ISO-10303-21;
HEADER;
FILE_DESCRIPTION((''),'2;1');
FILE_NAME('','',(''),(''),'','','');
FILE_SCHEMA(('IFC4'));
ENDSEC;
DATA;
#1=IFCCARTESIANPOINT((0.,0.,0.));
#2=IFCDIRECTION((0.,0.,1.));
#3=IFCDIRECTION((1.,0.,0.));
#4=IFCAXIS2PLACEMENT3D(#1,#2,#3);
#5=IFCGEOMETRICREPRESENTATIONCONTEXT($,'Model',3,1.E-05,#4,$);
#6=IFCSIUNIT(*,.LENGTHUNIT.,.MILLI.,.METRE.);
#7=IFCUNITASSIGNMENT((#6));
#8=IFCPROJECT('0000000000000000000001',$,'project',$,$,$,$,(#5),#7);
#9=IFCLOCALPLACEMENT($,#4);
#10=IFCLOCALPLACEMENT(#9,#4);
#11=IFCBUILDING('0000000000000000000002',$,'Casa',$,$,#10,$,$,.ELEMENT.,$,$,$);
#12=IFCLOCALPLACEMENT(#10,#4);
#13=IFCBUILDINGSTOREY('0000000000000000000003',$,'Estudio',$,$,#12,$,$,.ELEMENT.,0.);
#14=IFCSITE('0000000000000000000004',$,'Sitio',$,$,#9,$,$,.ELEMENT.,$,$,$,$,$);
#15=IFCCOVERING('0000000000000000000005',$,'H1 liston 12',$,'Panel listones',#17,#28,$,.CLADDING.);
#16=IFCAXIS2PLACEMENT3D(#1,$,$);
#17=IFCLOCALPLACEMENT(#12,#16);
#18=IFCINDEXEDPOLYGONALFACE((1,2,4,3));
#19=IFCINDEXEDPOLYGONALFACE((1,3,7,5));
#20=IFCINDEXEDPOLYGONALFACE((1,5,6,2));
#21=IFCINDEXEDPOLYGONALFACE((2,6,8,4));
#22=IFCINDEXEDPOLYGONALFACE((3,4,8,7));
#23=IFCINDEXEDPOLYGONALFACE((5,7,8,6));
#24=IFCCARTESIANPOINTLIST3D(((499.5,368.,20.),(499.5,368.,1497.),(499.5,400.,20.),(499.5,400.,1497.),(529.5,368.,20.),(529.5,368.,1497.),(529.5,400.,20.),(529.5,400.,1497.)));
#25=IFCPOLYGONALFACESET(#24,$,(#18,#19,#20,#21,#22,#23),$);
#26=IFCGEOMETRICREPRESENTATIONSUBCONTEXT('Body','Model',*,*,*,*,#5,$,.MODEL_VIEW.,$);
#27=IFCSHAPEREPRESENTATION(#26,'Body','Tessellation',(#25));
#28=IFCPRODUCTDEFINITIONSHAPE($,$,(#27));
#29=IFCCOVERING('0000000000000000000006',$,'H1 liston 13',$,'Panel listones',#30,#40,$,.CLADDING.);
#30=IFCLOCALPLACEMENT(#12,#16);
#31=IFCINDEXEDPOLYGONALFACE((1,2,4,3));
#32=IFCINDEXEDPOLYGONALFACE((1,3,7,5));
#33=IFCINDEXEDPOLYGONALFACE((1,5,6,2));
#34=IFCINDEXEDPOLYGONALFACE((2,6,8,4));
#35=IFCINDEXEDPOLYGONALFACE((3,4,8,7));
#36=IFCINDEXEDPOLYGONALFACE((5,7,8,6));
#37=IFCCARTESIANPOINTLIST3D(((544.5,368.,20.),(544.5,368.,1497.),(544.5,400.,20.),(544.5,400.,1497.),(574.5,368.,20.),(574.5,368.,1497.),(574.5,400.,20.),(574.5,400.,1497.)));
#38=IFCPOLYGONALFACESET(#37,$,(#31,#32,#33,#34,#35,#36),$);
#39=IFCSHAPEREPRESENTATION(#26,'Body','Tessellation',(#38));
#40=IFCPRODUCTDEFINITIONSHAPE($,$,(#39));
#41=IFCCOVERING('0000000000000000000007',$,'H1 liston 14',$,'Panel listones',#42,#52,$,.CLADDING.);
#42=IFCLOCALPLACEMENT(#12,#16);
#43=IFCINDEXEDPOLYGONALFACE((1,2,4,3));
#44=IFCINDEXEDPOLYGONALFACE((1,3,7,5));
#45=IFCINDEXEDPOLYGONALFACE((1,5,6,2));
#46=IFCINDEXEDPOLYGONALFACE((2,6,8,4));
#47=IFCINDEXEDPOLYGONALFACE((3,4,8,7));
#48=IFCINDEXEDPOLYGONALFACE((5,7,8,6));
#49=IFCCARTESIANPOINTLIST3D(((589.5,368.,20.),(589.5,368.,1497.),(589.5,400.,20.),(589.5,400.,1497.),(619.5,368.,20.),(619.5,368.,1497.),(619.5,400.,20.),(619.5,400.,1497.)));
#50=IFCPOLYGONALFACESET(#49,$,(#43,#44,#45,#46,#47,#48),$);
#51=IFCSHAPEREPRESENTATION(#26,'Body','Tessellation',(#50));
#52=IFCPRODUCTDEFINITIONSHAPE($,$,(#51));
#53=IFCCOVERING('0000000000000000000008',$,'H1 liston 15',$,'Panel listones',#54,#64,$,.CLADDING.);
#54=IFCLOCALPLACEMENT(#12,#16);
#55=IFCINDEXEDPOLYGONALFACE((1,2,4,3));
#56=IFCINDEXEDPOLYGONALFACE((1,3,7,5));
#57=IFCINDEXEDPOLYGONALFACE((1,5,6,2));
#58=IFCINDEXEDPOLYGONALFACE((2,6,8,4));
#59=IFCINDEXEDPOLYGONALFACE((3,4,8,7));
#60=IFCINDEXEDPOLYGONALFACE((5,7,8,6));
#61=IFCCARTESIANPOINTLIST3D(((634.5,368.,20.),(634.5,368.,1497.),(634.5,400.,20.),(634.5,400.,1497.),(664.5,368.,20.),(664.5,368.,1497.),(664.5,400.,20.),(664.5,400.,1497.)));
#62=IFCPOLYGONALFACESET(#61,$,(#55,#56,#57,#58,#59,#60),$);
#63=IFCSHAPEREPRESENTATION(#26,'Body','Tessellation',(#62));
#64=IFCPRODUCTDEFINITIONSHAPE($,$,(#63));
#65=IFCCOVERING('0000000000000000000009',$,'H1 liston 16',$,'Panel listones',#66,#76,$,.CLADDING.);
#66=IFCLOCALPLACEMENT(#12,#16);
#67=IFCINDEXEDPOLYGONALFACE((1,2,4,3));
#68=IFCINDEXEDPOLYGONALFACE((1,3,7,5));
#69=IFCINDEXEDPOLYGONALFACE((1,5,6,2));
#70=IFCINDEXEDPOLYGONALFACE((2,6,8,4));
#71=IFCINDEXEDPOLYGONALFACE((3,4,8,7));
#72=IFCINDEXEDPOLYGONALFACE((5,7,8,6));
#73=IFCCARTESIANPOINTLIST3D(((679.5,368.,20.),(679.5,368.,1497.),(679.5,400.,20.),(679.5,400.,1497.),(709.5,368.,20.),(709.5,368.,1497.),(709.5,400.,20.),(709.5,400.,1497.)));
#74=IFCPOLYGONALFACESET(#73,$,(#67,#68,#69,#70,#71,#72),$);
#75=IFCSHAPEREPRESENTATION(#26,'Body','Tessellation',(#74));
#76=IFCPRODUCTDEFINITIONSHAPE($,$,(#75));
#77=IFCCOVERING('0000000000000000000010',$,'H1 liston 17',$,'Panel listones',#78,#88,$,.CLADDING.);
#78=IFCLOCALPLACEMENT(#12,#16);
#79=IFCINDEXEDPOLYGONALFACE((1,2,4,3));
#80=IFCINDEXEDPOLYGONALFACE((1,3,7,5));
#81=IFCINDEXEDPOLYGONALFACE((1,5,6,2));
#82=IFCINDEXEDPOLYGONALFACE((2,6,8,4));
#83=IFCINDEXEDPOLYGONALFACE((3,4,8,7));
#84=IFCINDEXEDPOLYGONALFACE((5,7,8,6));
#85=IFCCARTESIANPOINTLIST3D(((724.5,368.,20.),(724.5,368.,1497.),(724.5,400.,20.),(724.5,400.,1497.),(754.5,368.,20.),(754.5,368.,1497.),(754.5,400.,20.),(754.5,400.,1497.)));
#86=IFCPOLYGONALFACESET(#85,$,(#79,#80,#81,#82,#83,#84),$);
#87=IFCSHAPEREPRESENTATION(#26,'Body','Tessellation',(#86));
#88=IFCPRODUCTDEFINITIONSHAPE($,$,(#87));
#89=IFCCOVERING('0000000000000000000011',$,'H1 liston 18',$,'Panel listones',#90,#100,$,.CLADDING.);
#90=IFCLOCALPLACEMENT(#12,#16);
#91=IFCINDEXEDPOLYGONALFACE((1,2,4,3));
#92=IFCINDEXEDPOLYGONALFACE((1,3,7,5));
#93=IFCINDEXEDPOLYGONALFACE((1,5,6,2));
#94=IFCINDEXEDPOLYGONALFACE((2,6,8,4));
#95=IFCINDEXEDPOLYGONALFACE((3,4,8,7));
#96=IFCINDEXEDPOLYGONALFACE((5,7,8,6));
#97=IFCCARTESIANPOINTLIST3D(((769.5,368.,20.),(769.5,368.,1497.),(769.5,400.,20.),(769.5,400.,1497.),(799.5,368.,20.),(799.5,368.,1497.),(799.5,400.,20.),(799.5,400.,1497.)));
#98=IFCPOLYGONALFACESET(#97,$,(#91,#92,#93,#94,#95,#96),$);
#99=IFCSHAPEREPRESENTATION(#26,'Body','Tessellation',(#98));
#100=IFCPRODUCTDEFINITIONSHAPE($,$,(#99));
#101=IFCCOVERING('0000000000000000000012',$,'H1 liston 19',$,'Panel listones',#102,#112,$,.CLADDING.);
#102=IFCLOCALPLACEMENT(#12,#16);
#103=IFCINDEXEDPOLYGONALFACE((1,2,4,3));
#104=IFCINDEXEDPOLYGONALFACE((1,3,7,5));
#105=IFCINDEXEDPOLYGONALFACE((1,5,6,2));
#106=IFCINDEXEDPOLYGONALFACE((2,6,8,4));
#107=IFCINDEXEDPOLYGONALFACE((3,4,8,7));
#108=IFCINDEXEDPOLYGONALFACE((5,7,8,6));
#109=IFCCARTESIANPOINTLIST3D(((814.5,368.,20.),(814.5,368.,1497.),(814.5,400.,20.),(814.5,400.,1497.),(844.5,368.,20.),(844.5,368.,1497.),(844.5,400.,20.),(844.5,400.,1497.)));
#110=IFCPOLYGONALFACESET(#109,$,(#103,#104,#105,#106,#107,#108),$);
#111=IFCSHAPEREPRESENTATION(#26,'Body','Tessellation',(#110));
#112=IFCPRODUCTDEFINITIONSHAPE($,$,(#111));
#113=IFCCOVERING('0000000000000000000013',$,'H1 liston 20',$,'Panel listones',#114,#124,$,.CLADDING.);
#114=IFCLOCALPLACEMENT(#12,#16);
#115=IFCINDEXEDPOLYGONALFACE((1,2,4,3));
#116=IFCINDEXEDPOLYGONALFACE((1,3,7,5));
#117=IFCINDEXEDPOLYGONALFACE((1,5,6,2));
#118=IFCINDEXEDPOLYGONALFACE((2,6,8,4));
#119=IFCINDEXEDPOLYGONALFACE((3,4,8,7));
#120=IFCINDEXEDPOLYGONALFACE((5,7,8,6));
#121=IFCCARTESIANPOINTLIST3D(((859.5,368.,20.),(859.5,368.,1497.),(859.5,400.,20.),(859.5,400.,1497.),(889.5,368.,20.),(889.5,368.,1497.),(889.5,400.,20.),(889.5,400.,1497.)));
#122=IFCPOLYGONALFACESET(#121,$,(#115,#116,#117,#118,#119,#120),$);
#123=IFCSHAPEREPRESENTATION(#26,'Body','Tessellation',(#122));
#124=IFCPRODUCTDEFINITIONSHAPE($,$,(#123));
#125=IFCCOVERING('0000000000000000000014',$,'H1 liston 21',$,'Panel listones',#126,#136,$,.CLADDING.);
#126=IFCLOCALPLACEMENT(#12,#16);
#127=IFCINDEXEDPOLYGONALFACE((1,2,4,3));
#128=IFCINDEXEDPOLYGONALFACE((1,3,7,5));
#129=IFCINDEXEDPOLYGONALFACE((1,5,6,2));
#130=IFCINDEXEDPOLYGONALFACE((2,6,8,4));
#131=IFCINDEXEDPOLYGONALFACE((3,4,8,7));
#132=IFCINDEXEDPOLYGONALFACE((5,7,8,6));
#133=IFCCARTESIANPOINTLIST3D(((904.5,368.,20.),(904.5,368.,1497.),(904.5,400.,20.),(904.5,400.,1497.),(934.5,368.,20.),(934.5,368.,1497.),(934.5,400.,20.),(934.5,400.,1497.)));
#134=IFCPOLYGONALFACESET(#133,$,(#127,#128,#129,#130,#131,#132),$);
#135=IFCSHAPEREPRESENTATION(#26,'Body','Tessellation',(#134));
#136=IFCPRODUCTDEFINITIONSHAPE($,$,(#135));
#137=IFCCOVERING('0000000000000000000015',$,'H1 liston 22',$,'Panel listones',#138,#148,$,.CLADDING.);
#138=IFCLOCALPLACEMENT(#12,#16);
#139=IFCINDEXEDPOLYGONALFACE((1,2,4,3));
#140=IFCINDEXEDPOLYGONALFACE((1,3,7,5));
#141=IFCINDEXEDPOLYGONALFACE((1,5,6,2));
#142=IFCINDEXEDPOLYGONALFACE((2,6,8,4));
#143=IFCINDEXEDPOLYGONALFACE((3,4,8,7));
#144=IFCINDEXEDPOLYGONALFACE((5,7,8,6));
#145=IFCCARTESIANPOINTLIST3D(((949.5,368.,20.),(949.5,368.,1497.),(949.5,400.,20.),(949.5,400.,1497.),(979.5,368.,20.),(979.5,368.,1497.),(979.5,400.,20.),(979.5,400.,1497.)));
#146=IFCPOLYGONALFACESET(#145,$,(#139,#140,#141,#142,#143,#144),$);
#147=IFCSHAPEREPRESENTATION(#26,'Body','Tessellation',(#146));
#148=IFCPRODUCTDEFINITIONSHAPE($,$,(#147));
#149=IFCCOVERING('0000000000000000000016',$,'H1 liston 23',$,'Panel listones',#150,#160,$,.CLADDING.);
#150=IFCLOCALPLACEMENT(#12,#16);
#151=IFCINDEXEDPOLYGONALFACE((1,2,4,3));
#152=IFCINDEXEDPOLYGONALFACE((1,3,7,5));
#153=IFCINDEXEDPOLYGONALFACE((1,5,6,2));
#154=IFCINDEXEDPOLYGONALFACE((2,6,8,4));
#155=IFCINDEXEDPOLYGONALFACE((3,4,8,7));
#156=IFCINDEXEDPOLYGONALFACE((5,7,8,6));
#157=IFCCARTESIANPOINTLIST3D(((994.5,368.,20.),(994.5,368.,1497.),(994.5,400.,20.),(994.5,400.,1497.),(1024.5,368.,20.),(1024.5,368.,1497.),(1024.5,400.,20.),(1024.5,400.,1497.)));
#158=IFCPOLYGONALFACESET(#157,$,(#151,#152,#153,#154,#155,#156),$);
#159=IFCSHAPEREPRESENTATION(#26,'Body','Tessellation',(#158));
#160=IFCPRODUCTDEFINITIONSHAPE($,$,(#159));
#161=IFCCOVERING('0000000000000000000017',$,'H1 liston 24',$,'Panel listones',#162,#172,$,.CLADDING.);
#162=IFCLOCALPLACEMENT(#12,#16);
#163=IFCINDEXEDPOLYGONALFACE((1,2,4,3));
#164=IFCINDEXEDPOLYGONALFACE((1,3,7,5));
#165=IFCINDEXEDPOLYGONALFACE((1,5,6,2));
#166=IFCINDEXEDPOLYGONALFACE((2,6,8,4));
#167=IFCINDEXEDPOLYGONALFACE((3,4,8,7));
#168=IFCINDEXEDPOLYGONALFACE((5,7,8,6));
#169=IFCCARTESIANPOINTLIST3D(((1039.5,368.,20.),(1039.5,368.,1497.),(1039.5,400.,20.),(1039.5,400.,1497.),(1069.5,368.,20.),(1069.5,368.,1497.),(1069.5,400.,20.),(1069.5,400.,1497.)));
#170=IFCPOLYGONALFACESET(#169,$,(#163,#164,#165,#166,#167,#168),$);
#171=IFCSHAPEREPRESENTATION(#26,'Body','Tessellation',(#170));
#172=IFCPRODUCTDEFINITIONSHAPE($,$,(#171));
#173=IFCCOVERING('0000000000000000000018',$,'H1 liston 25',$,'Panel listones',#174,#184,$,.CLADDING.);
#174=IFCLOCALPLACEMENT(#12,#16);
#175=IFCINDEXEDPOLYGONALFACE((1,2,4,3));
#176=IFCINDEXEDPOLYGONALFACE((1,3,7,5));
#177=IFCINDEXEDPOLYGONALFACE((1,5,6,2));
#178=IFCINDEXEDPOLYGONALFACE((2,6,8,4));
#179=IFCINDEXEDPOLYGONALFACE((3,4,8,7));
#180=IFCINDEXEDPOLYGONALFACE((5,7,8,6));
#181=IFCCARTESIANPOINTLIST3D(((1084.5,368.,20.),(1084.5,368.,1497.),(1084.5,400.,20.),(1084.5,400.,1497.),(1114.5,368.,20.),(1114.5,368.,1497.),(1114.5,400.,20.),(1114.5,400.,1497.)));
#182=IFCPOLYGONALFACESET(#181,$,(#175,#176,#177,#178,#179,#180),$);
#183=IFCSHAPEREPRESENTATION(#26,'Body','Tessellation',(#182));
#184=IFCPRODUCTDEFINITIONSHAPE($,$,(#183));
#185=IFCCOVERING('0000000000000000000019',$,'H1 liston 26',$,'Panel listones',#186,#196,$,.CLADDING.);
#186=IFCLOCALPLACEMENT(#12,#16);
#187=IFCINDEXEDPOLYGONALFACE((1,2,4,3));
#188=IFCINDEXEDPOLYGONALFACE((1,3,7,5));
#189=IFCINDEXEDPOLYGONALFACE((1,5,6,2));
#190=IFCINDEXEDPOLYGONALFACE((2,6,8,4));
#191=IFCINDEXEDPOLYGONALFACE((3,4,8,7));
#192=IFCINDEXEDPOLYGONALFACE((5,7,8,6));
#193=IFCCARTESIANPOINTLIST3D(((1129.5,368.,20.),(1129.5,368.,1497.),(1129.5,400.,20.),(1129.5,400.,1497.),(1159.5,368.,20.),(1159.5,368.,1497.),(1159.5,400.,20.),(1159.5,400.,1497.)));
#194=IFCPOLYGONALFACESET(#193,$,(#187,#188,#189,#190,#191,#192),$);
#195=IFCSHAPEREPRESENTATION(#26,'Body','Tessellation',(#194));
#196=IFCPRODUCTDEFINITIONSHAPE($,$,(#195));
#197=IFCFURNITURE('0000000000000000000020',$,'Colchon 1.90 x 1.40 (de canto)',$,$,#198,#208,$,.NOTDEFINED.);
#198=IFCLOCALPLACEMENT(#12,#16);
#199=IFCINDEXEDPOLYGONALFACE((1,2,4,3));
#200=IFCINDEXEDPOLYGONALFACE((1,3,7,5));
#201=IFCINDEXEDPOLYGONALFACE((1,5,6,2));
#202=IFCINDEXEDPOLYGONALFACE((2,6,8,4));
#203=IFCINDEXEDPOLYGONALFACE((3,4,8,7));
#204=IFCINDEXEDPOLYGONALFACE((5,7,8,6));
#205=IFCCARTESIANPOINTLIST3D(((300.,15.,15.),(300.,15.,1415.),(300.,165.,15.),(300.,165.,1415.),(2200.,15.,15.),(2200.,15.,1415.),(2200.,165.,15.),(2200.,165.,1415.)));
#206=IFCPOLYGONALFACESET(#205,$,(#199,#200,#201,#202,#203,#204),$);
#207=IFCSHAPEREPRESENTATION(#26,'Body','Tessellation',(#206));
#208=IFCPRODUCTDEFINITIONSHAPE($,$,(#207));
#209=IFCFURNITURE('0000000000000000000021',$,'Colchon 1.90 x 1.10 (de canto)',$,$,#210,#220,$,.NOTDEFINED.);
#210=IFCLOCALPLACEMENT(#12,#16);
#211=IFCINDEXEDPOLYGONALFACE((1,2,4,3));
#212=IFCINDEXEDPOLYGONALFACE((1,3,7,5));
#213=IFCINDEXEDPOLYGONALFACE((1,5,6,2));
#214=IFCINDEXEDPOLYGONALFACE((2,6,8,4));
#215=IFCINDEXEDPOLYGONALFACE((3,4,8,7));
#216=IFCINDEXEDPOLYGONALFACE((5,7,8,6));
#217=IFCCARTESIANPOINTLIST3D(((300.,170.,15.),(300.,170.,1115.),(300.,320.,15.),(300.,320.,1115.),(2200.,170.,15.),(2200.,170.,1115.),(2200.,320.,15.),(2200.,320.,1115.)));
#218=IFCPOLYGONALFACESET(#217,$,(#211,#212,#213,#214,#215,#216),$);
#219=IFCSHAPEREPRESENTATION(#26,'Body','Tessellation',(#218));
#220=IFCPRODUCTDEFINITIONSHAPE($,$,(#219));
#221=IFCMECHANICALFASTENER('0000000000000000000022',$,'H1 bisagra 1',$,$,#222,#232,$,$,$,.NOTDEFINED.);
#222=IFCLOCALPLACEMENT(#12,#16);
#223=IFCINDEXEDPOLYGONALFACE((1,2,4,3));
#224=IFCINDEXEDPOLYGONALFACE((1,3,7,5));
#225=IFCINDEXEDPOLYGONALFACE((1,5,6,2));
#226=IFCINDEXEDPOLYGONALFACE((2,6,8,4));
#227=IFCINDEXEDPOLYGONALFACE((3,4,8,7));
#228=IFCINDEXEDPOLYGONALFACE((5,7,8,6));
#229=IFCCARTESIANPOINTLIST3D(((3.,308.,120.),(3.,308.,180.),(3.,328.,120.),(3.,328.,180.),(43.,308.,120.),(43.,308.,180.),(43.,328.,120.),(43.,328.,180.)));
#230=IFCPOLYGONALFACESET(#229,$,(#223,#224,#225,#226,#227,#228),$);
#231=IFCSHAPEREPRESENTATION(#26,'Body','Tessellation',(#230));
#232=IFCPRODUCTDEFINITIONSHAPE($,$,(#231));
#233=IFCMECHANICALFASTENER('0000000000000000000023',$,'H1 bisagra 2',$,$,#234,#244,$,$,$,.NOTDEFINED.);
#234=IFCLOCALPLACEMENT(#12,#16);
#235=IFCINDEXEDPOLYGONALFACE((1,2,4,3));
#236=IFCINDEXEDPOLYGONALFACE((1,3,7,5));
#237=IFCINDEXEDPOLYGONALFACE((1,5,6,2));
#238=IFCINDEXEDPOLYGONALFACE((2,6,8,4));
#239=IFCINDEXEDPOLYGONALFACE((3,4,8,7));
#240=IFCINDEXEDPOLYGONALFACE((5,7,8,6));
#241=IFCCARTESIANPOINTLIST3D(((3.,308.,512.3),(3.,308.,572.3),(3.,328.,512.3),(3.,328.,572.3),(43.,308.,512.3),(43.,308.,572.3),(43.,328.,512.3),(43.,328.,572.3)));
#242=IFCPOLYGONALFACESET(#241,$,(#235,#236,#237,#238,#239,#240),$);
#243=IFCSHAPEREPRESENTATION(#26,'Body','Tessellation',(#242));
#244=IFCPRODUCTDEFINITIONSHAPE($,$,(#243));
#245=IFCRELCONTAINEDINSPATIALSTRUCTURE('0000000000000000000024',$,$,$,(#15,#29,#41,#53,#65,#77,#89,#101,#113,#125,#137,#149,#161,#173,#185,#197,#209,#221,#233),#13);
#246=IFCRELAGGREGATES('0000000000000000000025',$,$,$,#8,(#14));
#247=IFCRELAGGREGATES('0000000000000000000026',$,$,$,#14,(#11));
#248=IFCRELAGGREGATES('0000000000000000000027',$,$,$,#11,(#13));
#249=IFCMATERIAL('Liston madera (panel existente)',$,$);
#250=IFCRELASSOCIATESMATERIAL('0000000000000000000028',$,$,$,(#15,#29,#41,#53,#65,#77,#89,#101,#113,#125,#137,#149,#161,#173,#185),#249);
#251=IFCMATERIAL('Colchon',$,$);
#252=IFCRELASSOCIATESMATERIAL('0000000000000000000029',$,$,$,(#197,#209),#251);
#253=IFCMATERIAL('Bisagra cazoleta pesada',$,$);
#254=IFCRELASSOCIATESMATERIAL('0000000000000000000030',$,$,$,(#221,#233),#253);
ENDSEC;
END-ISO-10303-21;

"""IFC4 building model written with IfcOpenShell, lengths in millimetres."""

from ifc_helpers import new_model, si_unit, frame, frame_2d, origin_with_axes, place, context, subcontext, project, spatial, rectangle, extrude, material, element, save


model = new_model("IFC4")

# Units and contexts
model_context = context("Model", 3, precision=1e-05, world=origin_with_axes())
body_context = subcontext(model_context, "Body", "Model", "MODEL_VIEW")
ifc_project = project(units=[si_unit("LENGTHUNIT", "METRE", prefix="MILLI")], contexts=[model_context])

# Site, building, storey
site_placement = place(None, origin_with_axes())
site = spatial("IfcSite", under=ifc_project, at=site_placement, Name="Sitio", CompositionType="ELEMENT")
building_placement = place(site_placement, origin_with_axes())
building = spatial("IfcBuilding", under=site, at=building_placement, Name="Casa", CompositionType="ELEMENT")
storey_placement = place(building_placement, origin_with_axes())
storey = spatial("IfcBuildingStorey", under=building, at=storey_placement, Name="Estudio", CompositionType="ELEMENT", Elevation=0.0)

# Coverings
ifc_material_1 = material(Name="Liston madera (panel existente)")
for number, where, z_axis, x_axis, name in (
    (1, (499.5, 368.0, 20.0), (0.0, 0.0, 1.0), (1.0, 0.0, 0.0), "H1 liston 12"),
    (2, (544.5, 368.0, 20.0), (0.0, 0.0, 1.0), (1.0, 0.0, 0.0), "H1 liston 13"),
    (3, (589.5, 368.0, 20.0), (0.0, 0.0, 1.0), (1.0, 0.0, 0.0), "H1 liston 14"),
    (4, (634.5, 368.0, 20.0), (0.0, 0.0, 1.0), (1.0, 0.0, 0.0), "H1 liston 15"),
    (5, (679.5, 368.0, 20.0), (0.0, 0.0, 1.0), (1.0, 0.0, 0.0), "H1 liston 16"),
    (6, (724.5, 368.0, 20.0), (0.0, 0.0, 1.0), (1.0, 0.0, 0.0), "H1 liston 17"),
    (7, (769.5, 368.0, 20.0), (0.0, 0.0, 1.0), (1.0, 0.0, 0.0), "H1 liston 18"),
    (8, (814.5, 368.0, 20.0), (0.0, 0.0, 1.0), (1.0, 0.0, 0.0), "H1 liston 19"),
    (9, (859.5, 368.0, 20.0), (0.0, 0.0, 1.0), (1.0, 0.0, 0.0), "H1 liston 20"),
    (10, (904.5, 368.0, 20.0), (0.0, 0.0, 1.0), (1.0, 0.0, 0.0), "H1 liston 21"),
    (11, (949.5, 368.0, 20.0), (0.0, 0.0, 1.0), (1.0, 0.0, 0.0), "H1 liston 22"),
    (12, (994.5, 368.0, 20.0), (0.0, 0.0, 1.0), (1.0, 0.0, 0.0), "H1 liston 23"),
    (13, (1039.5, 368.0, 20.0), (0.0, 0.0, 1.0), (1.0, 0.0, 0.0), "H1 liston 24"),
    (14, (1084.5, 368.0, 20.0), (0.0, 0.0, 1.0), (1.0, 0.0, 0.0), "H1 liston 25"),
    (15, (1129.5, 368.0, 20.0), (0.0, 0.0, 1.0), (1.0, 0.0, 0.0), "H1 liston 26"),
):
    element("IfcCovering", number, at=place(storey_placement, frame(where, z_axis=z_axis, x_axis=x_axis)), inside=storey, material=ifc_material_1, Name=name, ObjectType="Panel listones", PredefinedType="CLADDING", context=body_context, shape_type="SweptSolid", body=[
        extrude(rectangle(XDim=30.0, YDim=32.0, at=frame_2d((15.0, 16.0))), origin_with_axes(), (0.0, 0.0, 1.0), 1477.0),
    ])

# Furniture
ifc_material_2 = material(Name="Colchon")
furniture_1_placement = place(storey_placement, frame((300.0, 15.0, 15.0), z_axis=(0.0, 0.0, 1.0), x_axis=(1.0, 0.0, 0.0)))
element("IfcFurniture", 16, at=furniture_1_placement, inside=storey, material=ifc_material_2, Name="Colchon 1.90 x 1.40 (de canto)", PredefinedType="NOTDEFINED", context=body_context, shape_type="SweptSolid", body=[
    extrude(rectangle(XDim=1900.0, YDim=150.0, at=frame_2d((950.0, 75.0))), origin_with_axes(), (0.0, 0.0, 1.0), 1400.0),
])
furniture_2_placement = place(storey_placement, frame((300.0, 170.0, 15.0), z_axis=(0.0, 0.0, 1.0), x_axis=(1.0, 0.0, 0.0)))
element("IfcFurniture", 17, at=furniture_2_placement, inside=storey, material=ifc_material_2, Name="Colchon 1.90 x 1.10 (de canto)", PredefinedType="NOTDEFINED", context=body_context, shape_type="SweptSolid", body=[
    extrude(rectangle(XDim=1900.0, YDim=150.0, at=frame_2d((950.0, 75.0))), origin_with_axes(), (0.0, 0.0, 1.0), 1100.0),
])

# Mechanical fasteners
ifc_material_3 = material(Name="Bisagra cazoleta pesada")
for number, where, z_axis, x_axis, name in (
    (18, (3.0, 308.0, 120.0), (0.0, 0.0, 1.0), (1.0, 0.0, 0.0), "H1 bisagra 1"),
    (19, (3.0, 308.0, 512.3), (0.0, 0.0, 1.0), (1.0, 0.0, 0.0), "H1 bisagra 2"),
):
    element("IfcMechanicalFastener", number, at=place(storey_placement, frame(where, z_axis=z_axis, x_axis=x_axis)), inside=storey, material=ifc_material_3, Name=name, PredefinedType="NOTDEFINED", context=body_context, shape_type="SweptSolid", body=[
        extrude(rectangle(XDim=40.0, YDim=20.0, at=frame_2d((20.0, 10.0))), origin_with_axes(), (0.0, 0.0, 1.0), 60.0),
    ])

save(model, "model.ifc")
